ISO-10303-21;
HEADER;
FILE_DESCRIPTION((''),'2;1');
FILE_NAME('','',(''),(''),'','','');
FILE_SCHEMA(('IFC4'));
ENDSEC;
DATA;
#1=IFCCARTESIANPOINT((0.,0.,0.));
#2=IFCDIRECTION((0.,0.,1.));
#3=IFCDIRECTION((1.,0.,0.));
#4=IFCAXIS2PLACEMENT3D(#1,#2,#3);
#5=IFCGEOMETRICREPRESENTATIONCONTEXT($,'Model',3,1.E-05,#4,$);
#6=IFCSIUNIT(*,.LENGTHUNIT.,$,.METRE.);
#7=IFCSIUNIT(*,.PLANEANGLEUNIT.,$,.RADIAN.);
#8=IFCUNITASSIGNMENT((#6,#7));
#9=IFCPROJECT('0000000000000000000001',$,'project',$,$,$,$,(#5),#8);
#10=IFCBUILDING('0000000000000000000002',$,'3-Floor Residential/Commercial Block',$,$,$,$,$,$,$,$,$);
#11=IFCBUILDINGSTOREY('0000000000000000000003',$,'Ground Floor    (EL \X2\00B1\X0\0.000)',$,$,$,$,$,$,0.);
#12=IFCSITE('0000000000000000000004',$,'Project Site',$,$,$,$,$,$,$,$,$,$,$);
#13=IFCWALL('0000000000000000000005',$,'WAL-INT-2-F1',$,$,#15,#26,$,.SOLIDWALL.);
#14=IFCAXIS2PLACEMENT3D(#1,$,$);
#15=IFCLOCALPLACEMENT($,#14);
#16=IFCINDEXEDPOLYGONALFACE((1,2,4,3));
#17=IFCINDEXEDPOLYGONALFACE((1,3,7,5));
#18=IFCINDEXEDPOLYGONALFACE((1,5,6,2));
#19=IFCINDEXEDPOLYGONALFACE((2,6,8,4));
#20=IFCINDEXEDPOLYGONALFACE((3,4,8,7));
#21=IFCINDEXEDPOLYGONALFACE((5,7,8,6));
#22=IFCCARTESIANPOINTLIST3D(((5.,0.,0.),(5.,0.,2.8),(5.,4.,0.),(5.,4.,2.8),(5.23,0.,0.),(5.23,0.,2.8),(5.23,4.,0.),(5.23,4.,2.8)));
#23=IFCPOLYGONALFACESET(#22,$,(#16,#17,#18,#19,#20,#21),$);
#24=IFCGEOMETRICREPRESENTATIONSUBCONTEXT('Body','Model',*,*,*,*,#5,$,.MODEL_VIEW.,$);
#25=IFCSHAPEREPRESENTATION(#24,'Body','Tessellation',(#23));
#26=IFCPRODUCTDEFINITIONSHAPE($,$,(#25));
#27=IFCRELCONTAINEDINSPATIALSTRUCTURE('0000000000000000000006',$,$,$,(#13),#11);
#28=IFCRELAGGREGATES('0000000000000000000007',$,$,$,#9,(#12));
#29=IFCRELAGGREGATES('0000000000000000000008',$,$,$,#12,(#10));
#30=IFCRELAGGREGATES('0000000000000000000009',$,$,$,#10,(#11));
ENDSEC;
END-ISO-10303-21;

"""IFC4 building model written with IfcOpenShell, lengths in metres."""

from ifc_helpers import new_model, si_unit, frame, frame_2d, origin_with_axes, place, context, subcontext, project, spatial, rectangle, extrude, element, save


model = new_model("IFC4")

# Units and contexts
model_context = context("Model", 3, precision=1e-05, world=origin_with_axes())
body_context = subcontext(model_context, "Body", "Model", "MODEL_VIEW")
ifc_project = project(units=[si_unit("LENGTHUNIT", "METRE"), si_unit("PLANEANGLEUNIT", "RADIAN")], contexts=[model_context])

# Site, building, storey
site = spatial("IfcSite", under=ifc_project, Name="Project Site")
building = spatial("IfcBuilding", under=site, Name="3-Floor Residential/Commercial Block")
storey = spatial("IfcBuildingStorey", under=building, Name="Ground Floor    (EL ±0.000)", Elevation=0.0)

# Wall
wall_1_placement = place(None, frame((5.0, 0.0, 0.0), z_axis=(0.0, 0.0, 1.0), x_axis=(1.0, 0.0, 0.0)))
element("IfcWall", 1, at=wall_1_placement, inside=storey, Name="WAL-INT-2-F1", PredefinedType="SOLIDWALL", context=body_context, shape_type="SweptSolid", body=[
    extrude(rectangle(XDim=0.23, YDim=4.0, at=frame_2d((0.115, 2.0))), origin_with_axes(), (0.0, 0.0, 1.0), 2.8),
])

save(model, "model.ifc")
